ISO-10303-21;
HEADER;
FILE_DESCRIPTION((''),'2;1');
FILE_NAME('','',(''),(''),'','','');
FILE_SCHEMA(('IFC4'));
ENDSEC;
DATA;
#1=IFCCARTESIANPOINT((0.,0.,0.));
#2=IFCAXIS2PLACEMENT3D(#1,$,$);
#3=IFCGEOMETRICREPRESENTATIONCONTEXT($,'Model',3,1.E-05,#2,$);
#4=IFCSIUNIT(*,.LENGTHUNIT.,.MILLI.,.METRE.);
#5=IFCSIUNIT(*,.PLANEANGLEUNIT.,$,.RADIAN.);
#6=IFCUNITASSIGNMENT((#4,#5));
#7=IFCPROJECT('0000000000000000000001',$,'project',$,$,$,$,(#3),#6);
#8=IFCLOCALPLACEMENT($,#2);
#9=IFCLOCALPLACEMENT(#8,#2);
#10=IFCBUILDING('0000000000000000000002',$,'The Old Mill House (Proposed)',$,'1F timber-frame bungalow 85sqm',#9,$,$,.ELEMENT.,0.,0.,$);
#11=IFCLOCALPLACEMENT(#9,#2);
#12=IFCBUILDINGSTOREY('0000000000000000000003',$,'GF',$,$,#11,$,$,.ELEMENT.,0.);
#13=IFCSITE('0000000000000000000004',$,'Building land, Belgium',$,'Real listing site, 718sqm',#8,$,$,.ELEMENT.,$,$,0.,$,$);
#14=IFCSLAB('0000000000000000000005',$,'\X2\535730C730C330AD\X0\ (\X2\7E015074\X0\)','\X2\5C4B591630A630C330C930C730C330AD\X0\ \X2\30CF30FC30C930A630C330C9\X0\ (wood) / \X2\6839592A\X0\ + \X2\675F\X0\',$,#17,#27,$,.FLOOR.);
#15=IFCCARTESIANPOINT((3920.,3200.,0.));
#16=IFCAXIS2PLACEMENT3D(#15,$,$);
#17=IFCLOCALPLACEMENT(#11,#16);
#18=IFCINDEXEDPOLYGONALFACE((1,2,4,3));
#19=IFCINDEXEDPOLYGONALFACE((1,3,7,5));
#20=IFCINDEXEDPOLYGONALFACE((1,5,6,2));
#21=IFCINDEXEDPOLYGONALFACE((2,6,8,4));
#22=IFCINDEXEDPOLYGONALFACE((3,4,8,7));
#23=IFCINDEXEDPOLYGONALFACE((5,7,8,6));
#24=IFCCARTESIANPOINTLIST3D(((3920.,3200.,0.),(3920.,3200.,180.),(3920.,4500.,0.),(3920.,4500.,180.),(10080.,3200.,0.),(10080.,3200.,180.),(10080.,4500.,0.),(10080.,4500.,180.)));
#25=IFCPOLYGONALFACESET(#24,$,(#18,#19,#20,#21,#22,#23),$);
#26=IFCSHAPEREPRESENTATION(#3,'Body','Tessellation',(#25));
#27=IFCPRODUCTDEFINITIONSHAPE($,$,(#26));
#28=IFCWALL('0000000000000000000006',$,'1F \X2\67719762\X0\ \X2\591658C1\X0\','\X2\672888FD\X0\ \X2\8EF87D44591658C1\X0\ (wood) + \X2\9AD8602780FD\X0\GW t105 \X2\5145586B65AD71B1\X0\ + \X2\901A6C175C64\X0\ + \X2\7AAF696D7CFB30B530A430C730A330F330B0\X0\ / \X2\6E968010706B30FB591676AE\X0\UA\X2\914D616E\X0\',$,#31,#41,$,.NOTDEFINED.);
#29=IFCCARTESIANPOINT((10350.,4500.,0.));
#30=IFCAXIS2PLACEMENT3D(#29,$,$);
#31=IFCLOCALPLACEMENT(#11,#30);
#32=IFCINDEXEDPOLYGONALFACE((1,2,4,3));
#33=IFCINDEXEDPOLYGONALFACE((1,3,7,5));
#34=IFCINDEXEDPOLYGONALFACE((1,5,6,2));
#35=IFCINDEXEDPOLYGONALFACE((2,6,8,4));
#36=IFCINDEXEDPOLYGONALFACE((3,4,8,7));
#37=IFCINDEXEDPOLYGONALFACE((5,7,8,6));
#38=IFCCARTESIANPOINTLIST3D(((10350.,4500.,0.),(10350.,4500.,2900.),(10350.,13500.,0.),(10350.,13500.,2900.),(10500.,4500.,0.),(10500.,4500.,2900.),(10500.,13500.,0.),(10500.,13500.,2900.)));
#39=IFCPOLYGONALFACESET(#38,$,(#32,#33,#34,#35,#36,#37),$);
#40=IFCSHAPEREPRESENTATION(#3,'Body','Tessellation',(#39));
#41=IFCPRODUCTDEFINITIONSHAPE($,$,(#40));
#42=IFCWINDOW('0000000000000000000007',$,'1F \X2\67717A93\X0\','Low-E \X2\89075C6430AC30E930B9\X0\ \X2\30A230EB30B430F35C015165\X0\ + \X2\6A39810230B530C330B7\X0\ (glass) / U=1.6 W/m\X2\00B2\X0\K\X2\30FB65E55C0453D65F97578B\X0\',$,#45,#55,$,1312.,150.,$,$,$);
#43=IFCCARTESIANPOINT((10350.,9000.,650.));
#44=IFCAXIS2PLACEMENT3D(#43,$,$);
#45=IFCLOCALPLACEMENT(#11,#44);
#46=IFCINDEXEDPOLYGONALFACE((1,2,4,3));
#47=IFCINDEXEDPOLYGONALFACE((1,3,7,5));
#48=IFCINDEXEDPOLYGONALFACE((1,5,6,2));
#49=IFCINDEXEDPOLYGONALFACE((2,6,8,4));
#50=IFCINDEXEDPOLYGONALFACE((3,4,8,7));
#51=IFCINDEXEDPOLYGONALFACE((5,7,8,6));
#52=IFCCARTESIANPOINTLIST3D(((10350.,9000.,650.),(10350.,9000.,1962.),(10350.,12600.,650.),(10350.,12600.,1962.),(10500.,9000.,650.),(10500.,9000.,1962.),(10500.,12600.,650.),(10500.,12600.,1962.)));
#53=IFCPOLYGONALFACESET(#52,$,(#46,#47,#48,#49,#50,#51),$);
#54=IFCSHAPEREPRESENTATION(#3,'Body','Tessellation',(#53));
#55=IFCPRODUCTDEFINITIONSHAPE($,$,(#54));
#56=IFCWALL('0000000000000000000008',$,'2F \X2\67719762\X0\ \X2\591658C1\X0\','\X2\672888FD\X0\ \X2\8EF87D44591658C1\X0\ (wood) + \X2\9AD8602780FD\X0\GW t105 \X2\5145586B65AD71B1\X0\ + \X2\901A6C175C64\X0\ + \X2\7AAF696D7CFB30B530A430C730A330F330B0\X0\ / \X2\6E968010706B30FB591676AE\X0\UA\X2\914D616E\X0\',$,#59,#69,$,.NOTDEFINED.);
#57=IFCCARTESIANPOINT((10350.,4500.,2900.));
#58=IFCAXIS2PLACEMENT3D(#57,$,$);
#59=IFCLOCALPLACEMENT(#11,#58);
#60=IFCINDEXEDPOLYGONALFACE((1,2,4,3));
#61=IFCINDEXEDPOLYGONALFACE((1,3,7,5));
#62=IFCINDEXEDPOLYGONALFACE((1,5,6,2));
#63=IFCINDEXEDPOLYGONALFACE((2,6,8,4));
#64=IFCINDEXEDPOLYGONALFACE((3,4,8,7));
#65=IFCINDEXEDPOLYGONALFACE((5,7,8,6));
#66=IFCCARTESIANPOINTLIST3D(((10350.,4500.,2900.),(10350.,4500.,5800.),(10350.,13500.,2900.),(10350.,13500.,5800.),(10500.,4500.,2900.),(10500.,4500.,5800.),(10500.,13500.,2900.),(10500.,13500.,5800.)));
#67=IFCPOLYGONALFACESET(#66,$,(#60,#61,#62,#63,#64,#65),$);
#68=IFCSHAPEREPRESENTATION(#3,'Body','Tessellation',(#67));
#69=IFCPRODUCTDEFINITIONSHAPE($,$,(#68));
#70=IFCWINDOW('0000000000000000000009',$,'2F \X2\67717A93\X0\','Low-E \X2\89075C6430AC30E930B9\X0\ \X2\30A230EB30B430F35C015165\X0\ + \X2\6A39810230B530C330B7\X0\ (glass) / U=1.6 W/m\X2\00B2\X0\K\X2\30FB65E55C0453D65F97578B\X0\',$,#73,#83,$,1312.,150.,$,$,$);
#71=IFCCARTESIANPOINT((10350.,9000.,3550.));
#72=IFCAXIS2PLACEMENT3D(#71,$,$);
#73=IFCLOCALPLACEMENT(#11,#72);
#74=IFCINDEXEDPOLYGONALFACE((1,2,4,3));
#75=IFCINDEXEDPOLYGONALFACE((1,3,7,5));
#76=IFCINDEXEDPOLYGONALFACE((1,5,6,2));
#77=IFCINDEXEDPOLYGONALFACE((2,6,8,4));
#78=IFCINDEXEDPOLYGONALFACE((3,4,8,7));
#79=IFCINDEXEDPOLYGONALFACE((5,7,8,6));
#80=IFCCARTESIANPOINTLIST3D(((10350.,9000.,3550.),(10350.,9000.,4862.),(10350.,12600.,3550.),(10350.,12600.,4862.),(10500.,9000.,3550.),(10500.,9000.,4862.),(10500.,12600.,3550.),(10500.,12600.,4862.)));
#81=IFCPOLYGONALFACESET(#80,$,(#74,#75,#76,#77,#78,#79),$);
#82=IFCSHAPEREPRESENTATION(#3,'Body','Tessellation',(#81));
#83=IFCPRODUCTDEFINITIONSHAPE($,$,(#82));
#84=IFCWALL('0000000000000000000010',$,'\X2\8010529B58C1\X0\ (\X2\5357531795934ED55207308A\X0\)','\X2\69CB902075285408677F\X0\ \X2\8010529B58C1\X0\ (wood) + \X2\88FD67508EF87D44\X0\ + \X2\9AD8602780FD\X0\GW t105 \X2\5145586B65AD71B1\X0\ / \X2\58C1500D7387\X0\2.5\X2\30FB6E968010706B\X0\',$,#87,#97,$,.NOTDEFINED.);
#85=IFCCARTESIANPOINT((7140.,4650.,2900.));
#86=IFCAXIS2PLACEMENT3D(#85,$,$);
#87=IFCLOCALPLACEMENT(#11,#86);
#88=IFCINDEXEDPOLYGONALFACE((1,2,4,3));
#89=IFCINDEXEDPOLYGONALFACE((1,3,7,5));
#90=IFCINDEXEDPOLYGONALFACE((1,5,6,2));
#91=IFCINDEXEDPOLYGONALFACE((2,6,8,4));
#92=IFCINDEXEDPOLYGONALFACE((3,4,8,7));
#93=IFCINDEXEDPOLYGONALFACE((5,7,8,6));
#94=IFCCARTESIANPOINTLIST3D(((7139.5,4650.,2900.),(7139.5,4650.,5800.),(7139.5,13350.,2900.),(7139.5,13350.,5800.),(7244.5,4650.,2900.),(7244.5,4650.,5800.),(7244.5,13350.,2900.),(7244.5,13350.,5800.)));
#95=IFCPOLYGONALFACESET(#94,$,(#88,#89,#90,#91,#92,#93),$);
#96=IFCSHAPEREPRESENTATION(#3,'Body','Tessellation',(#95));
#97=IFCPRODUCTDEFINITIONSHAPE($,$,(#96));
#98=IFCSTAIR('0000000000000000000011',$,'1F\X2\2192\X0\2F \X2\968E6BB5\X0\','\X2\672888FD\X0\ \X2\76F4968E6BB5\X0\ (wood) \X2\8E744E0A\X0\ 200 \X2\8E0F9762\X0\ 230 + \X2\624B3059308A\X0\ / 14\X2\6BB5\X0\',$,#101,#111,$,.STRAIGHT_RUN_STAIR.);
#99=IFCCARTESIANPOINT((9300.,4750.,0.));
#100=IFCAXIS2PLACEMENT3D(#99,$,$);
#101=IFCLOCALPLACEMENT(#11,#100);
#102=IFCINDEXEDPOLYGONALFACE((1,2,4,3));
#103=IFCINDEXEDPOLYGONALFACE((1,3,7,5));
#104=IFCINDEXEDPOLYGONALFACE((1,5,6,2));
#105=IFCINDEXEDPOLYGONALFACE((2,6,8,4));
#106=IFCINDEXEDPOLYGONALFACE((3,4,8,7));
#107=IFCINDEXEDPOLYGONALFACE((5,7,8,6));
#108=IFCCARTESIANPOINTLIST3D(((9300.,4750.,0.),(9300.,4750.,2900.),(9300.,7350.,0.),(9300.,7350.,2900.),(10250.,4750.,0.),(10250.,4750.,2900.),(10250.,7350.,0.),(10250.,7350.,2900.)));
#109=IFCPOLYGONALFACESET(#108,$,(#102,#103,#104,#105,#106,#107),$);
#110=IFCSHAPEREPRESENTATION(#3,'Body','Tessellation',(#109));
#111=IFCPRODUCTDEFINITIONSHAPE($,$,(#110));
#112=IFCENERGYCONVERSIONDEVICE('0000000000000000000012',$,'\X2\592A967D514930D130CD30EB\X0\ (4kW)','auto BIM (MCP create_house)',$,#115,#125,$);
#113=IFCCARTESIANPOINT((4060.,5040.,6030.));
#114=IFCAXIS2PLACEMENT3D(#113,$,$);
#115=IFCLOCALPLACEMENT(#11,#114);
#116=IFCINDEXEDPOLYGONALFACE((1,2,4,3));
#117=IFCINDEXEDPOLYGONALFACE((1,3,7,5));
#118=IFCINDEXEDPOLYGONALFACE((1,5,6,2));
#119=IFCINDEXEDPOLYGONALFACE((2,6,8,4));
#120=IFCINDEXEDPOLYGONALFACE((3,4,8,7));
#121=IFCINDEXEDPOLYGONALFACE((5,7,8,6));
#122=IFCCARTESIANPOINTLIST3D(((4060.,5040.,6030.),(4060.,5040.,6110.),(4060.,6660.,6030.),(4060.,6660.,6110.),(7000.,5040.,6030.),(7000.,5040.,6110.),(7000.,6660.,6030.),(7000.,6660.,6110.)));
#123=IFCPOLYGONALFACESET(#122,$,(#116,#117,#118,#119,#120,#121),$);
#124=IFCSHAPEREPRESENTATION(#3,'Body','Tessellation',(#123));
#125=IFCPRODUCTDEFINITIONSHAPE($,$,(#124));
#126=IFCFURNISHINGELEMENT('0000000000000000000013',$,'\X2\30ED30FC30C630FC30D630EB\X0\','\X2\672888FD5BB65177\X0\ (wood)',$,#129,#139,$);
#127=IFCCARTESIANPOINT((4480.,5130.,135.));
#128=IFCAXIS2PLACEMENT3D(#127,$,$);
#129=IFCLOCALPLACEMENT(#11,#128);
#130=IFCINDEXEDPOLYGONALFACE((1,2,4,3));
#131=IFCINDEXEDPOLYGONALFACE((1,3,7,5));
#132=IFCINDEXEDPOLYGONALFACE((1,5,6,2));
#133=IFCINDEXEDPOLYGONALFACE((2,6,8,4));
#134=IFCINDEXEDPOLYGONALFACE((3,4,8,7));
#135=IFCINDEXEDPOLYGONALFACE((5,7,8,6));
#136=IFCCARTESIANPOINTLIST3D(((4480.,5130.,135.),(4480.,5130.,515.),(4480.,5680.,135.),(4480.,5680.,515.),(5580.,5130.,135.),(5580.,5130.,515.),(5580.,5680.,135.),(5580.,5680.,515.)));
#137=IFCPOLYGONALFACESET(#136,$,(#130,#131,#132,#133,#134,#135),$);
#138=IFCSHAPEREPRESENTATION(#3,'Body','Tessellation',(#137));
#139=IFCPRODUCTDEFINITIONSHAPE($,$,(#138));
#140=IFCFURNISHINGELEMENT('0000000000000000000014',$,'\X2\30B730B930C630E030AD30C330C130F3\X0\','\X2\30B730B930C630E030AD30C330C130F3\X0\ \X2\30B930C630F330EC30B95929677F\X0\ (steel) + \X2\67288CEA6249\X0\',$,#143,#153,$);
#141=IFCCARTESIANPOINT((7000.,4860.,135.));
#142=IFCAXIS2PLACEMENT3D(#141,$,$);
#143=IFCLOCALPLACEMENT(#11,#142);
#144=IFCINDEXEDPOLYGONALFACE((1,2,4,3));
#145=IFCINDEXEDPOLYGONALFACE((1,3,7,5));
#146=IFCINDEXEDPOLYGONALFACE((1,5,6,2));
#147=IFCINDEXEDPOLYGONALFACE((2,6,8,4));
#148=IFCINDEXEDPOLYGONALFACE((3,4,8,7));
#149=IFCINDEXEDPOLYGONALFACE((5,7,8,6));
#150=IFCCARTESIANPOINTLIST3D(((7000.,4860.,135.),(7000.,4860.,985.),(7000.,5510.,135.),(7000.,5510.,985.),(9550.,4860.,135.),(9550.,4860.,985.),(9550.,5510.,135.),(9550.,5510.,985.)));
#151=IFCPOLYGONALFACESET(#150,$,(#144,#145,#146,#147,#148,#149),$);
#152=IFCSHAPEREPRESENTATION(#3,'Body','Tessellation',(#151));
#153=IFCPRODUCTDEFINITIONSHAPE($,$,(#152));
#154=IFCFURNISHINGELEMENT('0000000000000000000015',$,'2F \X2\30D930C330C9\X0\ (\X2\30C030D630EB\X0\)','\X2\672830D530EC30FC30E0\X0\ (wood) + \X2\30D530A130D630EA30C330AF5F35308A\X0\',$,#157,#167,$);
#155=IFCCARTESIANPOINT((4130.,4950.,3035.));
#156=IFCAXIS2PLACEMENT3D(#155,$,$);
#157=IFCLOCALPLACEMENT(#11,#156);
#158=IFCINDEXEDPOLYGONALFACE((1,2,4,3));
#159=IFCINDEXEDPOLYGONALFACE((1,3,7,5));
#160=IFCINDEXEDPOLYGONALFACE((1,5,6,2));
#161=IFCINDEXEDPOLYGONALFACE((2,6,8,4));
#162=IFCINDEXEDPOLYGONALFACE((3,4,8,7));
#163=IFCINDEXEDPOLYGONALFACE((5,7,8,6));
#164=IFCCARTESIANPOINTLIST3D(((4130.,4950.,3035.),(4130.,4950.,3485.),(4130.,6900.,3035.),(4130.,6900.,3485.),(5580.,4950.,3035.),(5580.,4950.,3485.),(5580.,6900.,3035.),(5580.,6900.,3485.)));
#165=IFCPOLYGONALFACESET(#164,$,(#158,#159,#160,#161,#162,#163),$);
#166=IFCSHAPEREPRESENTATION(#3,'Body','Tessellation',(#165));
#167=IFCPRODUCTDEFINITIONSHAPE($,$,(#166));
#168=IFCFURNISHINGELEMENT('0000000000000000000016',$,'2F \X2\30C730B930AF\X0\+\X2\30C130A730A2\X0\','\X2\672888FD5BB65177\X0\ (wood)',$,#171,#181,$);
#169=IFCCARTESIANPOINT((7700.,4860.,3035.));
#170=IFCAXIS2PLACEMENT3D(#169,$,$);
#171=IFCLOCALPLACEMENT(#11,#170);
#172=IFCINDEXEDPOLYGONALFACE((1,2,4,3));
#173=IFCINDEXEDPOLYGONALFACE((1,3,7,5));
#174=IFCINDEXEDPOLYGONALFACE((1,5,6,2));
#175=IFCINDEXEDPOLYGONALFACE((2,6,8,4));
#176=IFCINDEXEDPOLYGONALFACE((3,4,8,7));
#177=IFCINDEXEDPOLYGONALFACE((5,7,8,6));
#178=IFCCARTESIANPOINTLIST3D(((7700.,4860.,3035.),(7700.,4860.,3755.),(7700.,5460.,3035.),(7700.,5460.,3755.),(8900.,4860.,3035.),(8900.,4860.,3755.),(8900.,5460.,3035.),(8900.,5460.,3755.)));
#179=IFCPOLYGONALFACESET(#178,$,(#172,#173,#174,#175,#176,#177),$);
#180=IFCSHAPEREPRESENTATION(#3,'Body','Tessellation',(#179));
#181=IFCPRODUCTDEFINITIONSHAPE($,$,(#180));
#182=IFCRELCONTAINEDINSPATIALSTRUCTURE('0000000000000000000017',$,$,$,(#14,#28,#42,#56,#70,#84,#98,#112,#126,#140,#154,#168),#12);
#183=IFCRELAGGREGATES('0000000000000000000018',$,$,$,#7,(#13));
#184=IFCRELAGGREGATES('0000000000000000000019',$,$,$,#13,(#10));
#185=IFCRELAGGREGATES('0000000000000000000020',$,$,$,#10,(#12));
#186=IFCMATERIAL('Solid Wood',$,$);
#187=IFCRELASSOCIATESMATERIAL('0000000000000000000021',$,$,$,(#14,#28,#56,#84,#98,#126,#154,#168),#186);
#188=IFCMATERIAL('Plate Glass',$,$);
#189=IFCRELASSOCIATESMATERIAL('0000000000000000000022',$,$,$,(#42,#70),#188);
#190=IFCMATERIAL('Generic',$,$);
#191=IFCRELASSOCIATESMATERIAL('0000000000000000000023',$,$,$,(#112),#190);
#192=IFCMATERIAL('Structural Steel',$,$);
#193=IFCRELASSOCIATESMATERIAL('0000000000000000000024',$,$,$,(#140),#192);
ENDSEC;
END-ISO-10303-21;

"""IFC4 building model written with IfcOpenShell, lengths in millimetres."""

from ifc_helpers import new_model, si_unit, frame, frame_2d, origin, place, context, project, spatial, rectangle, extrude, material, element, fill, save


model = new_model("IFC4")

# Units and contexts
model_context = context("Model", 3, precision=1e-05, world=origin())
ifc_project = project(units=[si_unit("LENGTHUNIT", "METRE", prefix="MILLI"), si_unit("PLANEANGLEUNIT", "RADIAN")], contexts=[model_context])

# Site, building, storey
site_placement = place(None, origin())
site = spatial("IfcSite", under=ifc_project, at=site_placement, Name="Building land, Belgium", ObjectType="Real listing site, 718sqm", CompositionType="ELEMENT", RefElevation=0.0)
building_placement = place(site_placement, origin())
building = spatial("IfcBuilding", under=site, at=building_placement, Name="The Old Mill House (Proposed)", ObjectType="1F timber-frame bungalow 85sqm", CompositionType="ELEMENT", ElevationOfRefHeight=0.0, ElevationOfTerrain=0.0)
storey_placement = place(building_placement, origin())
storey = spatial("IfcBuildingStorey", under=building, at=storey_placement, Name="GF", CompositionType="ELEMENT", Elevation=0.0)

# Slab
ifc_material_1 = material(Name="Solid Wood")
slab_placement = place(storey_placement, frame((3920.0, 3200.0, 0.0)))
element("IfcSlab", 1, at=slab_placement, inside=storey, material=ifc_material_1, Name="南デッキ (縁側)", Description="屋外ウッドデッキ ハードウッド (wood) / 根太 + 束", PredefinedType="FLOOR", context=model_context, shape_type="SweptSolid", body=[
    extrude(rectangle(XDim=6160.0, YDim=1300.0, at=frame_2d((3080.0, 650.0))), frame((3920.0, 3200.0, 0.0)), (0.0, 0.0, 1.0), 180.0),
])

# Wall, opening, window
wall_1_placement = place(storey_placement, frame((10350.0, 4500.0, 0.0)))
wall_1 = element("IfcWall", 2, at=wall_1_placement, inside=storey, material=ifc_material_1, Name="1F 東面 外壁", Description="木製 軸組外壁 (wood) + 高性能GW t105 充填断熱 + 通気層 + 窯業系サイディング / 準耐火・外皮UA配慮", PredefinedType="NOTDEFINED", context=model_context, shape_type="SweptSolid", body=[
    extrude(rectangle(XDim=150.0, YDim=9000.0, at=frame_2d((75.0, 4500.0))), frame((10350.0, 4500.0, 0.0)), (0.0, 0.0, 1.0), 2900.0),
])
opening_1_placement = place(storey_placement, frame((10350.0, 9000.0, 650.0)))
opening_1 = element("IfcOpeningElement", 3, at=opening_1_placement, cuts=wall_1, PredefinedType="NOTDEFINED", context=model_context, shape_type="SweptSolid", body=[
    extrude(rectangle(XDim=150.0, YDim=3600.0, at=frame_2d((75.0, 1800.0))), frame((10350.0, 9000.0, 650.0)), (0.0, 0.0, 1.0), 1312.0),
])
ifc_material_2 = material(Name="Plate Glass")
window_1_placement = place(storey_placement, frame((10350.0, 9000.0, 650.0)))
window_1 = element("IfcWindow", 4, at=window_1_placement, inside=storey, material=ifc_material_2, Name="1F 東窓", Description="Low-E 複層ガラス アルゴン封入 + 樹脂サッシ (glass) / U=1.6 W/m²K・日射取得型", OverallHeight=1312.0, OverallWidth=150.0, context=model_context, shape_type="SweptSolid", body=[
    extrude(rectangle(XDim=150.0, YDim=3600.0, at=frame_2d((75.0, 1800.0))), frame((10350.0, 9000.0, 650.0)), (0.0, 0.0, 1.0), 1312.0),
])
fill(opening_1, window_1)

# Wall, opening, window
wall_2_placement = place(storey_placement, frame((10350.0, 4500.0, 2900.0)))
wall_2 = element("IfcWall", 5, at=wall_2_placement, inside=storey, material=ifc_material_1, Name="2F 東面 外壁", Description="木製 軸組外壁 (wood) + 高性能GW t105 充填断熱 + 通気層 + 窯業系サイディング / 準耐火・外皮UA配慮", PredefinedType="NOTDEFINED", context=model_context, shape_type="SweptSolid", body=[
    extrude(rectangle(XDim=150.0, YDim=9000.0, at=frame_2d((75.0, 4500.0))), frame((10350.0, 4500.0, 2900.0)), (0.0, 0.0, 1.0), 2900.0),
])
opening_2_placement = place(storey_placement, frame((10350.0, 9000.0, 3550.0)))
opening_2 = element("IfcOpeningElement", 6, at=opening_2_placement, cuts=wall_2, PredefinedType="NOTDEFINED", context=model_context, shape_type="SweptSolid", body=[
    extrude(rectangle(XDim=150.0, YDim=3600.0, at=frame_2d((75.0, 1800.0))), frame((10350.0, 9000.0, 3550.0)), (0.0, 0.0, 1.0), 1312.0),
])
window_2_placement = place(storey_placement, frame((10350.0, 9000.0, 3550.0)))
window_2 = element("IfcWindow", 7, at=window_2_placement, inside=storey, material=ifc_material_2, Name="2F 東窓", Description="Low-E 複層ガラス アルゴン封入 + 樹脂サッシ (glass) / U=1.6 W/m²K・日射取得型", OverallHeight=1312.0, OverallWidth=150.0, context=model_context, shape_type="SweptSolid", body=[
    extrude(rectangle(XDim=150.0, YDim=3600.0, at=frame_2d((75.0, 1800.0))), frame((10350.0, 9000.0, 3550.0)), (0.0, 0.0, 1.0), 1312.0),
])
fill(opening_2, window_2)

# Wall
wall_3_placement = place(storey_placement, frame((7140.0, 4650.0, 2900.0)))
element("IfcWall", 8, at=wall_3_placement, inside=storey, material=ifc_material_1, Name="耐力壁 (南北間仕切り)", Description="構造用合板 耐力壁 (wood) + 製材軸組 + 高性能GW t105 充填断熱 / 壁倍率2.5・準耐火", PredefinedType="NOTDEFINED", context=model_context, shape_type="SweptSolid", body=[
    extrude(rectangle(XDim=105.0, YDim=8700.0, at=frame_2d((52.0, 4350.0))), frame((7140.0, 4650.0, 2900.0)), (0.0, 0.0, 1.0), 2900.0),
])

# Stair
stair_placement = place(storey_placement, frame((9300.0, 4750.0, 0.0)))
element("IfcStair", 9, at=stair_placement, inside=storey, material=ifc_material_1, Name="1F→2F 階段", Description="木製 直階段 (wood) 蹴上 200 踏面 230 + 手すり / 14段", PredefinedType="STRAIGHT_RUN_STAIR", context=model_context, shape_type="SweptSolid", body=[
    extrude(rectangle(XDim=950.0, YDim=2600.0, at=frame_2d((475.0, 1300.0))), frame((9300.0, 4750.0, 0.0)), (0.0, 0.0, 1.0), 2900.0),
])

# Energy conversion device
ifc_material_3 = material(Name="Generic")
energy_conversion_device_placement = place(storey_placement, frame((4060.0, 5040.0, 6030.0)))
element("IfcEnergyConversionDevice", 10, at=energy_conversion_device_placement, inside=storey, material=ifc_material_3, Name="太陽光パネル (4kW)", Description="auto BIM (MCP create_house)", context=model_context, shape_type="SweptSolid", body=[
    extrude(rectangle(XDim=2940.0, YDim=1620.0, at=frame_2d((1470.0, 810.0))), frame((4060.0, 5040.0, 6030.0)), (0.0, 0.0, 1.0), 80.0),
])

# Furnishing elements
furnishing_1_placement = place(storey_placement, frame((4480.0, 5130.0, 135.0)))
element("IfcFurnishingElement", 11, at=furnishing_1_placement, inside=storey, material=ifc_material_1, Name="ローテーブル", Description="木製家具 (wood)", context=model_context, shape_type="SweptSolid", body=[
    extrude(rectangle(XDim=1100.0, YDim=550.0, at=frame_2d((550.0, 275.0))), frame((4480.0, 5130.0, 135.0)), (0.0, 0.0, 1.0), 380.0),
])
ifc_material_4 = material(Name="Structural Steel")
furnishing_2_placement = place(storey_placement, frame((7000.0, 4860.0, 135.0)))
element("IfcFurnishingElement", 12, at=furnishing_2_placement, inside=storey, material=ifc_material_4, Name="システムキッチン", Description="システムキッチン ステンレス天板 (steel) + 木質扉", context=model_context, shape_type="SweptSolid", body=[
    extrude(rectangle(XDim=2550.0, YDim=650.0, at=frame_2d((1275.0, 325.0))), frame((7000.0, 4860.0, 135.0)), (0.0, 0.0, 1.0), 850.0),
])
furnishing_3_placement = place(storey_placement, frame((4130.0, 4950.0, 3035.0)))
element("IfcFurnishingElement", 13, at=furnishing_3_placement, inside=storey, material=ifc_material_1, Name="2F ベッド (ダブル)", Description="木フレーム (wood) + ファブリック張り", context=model_context, shape_type="SweptSolid", body=[
    extrude(rectangle(XDim=1450.0, YDim=1950.0, at=frame_2d((725.0, 975.0))), frame((4130.0, 4950.0, 3035.0)), (0.0, 0.0, 1.0), 450.0),
])
furnishing_4_placement = place(storey_placement, frame((7700.0, 4860.0, 3035.0)))
element("IfcFurnishingElement", 14, at=furnishing_4_placement, inside=storey, material=ifc_material_1, Name="2F デスク+チェア", Description="木製家具 (wood)", context=model_context, shape_type="SweptSolid", body=[
    extrude(rectangle(XDim=1200.0, YDim=600.0, at=frame_2d((600.0, 300.0))), frame((7700.0, 4860.0, 3035.0)), (0.0, 0.0, 1.0), 720.0),
])

save(model, "model.ifc")
